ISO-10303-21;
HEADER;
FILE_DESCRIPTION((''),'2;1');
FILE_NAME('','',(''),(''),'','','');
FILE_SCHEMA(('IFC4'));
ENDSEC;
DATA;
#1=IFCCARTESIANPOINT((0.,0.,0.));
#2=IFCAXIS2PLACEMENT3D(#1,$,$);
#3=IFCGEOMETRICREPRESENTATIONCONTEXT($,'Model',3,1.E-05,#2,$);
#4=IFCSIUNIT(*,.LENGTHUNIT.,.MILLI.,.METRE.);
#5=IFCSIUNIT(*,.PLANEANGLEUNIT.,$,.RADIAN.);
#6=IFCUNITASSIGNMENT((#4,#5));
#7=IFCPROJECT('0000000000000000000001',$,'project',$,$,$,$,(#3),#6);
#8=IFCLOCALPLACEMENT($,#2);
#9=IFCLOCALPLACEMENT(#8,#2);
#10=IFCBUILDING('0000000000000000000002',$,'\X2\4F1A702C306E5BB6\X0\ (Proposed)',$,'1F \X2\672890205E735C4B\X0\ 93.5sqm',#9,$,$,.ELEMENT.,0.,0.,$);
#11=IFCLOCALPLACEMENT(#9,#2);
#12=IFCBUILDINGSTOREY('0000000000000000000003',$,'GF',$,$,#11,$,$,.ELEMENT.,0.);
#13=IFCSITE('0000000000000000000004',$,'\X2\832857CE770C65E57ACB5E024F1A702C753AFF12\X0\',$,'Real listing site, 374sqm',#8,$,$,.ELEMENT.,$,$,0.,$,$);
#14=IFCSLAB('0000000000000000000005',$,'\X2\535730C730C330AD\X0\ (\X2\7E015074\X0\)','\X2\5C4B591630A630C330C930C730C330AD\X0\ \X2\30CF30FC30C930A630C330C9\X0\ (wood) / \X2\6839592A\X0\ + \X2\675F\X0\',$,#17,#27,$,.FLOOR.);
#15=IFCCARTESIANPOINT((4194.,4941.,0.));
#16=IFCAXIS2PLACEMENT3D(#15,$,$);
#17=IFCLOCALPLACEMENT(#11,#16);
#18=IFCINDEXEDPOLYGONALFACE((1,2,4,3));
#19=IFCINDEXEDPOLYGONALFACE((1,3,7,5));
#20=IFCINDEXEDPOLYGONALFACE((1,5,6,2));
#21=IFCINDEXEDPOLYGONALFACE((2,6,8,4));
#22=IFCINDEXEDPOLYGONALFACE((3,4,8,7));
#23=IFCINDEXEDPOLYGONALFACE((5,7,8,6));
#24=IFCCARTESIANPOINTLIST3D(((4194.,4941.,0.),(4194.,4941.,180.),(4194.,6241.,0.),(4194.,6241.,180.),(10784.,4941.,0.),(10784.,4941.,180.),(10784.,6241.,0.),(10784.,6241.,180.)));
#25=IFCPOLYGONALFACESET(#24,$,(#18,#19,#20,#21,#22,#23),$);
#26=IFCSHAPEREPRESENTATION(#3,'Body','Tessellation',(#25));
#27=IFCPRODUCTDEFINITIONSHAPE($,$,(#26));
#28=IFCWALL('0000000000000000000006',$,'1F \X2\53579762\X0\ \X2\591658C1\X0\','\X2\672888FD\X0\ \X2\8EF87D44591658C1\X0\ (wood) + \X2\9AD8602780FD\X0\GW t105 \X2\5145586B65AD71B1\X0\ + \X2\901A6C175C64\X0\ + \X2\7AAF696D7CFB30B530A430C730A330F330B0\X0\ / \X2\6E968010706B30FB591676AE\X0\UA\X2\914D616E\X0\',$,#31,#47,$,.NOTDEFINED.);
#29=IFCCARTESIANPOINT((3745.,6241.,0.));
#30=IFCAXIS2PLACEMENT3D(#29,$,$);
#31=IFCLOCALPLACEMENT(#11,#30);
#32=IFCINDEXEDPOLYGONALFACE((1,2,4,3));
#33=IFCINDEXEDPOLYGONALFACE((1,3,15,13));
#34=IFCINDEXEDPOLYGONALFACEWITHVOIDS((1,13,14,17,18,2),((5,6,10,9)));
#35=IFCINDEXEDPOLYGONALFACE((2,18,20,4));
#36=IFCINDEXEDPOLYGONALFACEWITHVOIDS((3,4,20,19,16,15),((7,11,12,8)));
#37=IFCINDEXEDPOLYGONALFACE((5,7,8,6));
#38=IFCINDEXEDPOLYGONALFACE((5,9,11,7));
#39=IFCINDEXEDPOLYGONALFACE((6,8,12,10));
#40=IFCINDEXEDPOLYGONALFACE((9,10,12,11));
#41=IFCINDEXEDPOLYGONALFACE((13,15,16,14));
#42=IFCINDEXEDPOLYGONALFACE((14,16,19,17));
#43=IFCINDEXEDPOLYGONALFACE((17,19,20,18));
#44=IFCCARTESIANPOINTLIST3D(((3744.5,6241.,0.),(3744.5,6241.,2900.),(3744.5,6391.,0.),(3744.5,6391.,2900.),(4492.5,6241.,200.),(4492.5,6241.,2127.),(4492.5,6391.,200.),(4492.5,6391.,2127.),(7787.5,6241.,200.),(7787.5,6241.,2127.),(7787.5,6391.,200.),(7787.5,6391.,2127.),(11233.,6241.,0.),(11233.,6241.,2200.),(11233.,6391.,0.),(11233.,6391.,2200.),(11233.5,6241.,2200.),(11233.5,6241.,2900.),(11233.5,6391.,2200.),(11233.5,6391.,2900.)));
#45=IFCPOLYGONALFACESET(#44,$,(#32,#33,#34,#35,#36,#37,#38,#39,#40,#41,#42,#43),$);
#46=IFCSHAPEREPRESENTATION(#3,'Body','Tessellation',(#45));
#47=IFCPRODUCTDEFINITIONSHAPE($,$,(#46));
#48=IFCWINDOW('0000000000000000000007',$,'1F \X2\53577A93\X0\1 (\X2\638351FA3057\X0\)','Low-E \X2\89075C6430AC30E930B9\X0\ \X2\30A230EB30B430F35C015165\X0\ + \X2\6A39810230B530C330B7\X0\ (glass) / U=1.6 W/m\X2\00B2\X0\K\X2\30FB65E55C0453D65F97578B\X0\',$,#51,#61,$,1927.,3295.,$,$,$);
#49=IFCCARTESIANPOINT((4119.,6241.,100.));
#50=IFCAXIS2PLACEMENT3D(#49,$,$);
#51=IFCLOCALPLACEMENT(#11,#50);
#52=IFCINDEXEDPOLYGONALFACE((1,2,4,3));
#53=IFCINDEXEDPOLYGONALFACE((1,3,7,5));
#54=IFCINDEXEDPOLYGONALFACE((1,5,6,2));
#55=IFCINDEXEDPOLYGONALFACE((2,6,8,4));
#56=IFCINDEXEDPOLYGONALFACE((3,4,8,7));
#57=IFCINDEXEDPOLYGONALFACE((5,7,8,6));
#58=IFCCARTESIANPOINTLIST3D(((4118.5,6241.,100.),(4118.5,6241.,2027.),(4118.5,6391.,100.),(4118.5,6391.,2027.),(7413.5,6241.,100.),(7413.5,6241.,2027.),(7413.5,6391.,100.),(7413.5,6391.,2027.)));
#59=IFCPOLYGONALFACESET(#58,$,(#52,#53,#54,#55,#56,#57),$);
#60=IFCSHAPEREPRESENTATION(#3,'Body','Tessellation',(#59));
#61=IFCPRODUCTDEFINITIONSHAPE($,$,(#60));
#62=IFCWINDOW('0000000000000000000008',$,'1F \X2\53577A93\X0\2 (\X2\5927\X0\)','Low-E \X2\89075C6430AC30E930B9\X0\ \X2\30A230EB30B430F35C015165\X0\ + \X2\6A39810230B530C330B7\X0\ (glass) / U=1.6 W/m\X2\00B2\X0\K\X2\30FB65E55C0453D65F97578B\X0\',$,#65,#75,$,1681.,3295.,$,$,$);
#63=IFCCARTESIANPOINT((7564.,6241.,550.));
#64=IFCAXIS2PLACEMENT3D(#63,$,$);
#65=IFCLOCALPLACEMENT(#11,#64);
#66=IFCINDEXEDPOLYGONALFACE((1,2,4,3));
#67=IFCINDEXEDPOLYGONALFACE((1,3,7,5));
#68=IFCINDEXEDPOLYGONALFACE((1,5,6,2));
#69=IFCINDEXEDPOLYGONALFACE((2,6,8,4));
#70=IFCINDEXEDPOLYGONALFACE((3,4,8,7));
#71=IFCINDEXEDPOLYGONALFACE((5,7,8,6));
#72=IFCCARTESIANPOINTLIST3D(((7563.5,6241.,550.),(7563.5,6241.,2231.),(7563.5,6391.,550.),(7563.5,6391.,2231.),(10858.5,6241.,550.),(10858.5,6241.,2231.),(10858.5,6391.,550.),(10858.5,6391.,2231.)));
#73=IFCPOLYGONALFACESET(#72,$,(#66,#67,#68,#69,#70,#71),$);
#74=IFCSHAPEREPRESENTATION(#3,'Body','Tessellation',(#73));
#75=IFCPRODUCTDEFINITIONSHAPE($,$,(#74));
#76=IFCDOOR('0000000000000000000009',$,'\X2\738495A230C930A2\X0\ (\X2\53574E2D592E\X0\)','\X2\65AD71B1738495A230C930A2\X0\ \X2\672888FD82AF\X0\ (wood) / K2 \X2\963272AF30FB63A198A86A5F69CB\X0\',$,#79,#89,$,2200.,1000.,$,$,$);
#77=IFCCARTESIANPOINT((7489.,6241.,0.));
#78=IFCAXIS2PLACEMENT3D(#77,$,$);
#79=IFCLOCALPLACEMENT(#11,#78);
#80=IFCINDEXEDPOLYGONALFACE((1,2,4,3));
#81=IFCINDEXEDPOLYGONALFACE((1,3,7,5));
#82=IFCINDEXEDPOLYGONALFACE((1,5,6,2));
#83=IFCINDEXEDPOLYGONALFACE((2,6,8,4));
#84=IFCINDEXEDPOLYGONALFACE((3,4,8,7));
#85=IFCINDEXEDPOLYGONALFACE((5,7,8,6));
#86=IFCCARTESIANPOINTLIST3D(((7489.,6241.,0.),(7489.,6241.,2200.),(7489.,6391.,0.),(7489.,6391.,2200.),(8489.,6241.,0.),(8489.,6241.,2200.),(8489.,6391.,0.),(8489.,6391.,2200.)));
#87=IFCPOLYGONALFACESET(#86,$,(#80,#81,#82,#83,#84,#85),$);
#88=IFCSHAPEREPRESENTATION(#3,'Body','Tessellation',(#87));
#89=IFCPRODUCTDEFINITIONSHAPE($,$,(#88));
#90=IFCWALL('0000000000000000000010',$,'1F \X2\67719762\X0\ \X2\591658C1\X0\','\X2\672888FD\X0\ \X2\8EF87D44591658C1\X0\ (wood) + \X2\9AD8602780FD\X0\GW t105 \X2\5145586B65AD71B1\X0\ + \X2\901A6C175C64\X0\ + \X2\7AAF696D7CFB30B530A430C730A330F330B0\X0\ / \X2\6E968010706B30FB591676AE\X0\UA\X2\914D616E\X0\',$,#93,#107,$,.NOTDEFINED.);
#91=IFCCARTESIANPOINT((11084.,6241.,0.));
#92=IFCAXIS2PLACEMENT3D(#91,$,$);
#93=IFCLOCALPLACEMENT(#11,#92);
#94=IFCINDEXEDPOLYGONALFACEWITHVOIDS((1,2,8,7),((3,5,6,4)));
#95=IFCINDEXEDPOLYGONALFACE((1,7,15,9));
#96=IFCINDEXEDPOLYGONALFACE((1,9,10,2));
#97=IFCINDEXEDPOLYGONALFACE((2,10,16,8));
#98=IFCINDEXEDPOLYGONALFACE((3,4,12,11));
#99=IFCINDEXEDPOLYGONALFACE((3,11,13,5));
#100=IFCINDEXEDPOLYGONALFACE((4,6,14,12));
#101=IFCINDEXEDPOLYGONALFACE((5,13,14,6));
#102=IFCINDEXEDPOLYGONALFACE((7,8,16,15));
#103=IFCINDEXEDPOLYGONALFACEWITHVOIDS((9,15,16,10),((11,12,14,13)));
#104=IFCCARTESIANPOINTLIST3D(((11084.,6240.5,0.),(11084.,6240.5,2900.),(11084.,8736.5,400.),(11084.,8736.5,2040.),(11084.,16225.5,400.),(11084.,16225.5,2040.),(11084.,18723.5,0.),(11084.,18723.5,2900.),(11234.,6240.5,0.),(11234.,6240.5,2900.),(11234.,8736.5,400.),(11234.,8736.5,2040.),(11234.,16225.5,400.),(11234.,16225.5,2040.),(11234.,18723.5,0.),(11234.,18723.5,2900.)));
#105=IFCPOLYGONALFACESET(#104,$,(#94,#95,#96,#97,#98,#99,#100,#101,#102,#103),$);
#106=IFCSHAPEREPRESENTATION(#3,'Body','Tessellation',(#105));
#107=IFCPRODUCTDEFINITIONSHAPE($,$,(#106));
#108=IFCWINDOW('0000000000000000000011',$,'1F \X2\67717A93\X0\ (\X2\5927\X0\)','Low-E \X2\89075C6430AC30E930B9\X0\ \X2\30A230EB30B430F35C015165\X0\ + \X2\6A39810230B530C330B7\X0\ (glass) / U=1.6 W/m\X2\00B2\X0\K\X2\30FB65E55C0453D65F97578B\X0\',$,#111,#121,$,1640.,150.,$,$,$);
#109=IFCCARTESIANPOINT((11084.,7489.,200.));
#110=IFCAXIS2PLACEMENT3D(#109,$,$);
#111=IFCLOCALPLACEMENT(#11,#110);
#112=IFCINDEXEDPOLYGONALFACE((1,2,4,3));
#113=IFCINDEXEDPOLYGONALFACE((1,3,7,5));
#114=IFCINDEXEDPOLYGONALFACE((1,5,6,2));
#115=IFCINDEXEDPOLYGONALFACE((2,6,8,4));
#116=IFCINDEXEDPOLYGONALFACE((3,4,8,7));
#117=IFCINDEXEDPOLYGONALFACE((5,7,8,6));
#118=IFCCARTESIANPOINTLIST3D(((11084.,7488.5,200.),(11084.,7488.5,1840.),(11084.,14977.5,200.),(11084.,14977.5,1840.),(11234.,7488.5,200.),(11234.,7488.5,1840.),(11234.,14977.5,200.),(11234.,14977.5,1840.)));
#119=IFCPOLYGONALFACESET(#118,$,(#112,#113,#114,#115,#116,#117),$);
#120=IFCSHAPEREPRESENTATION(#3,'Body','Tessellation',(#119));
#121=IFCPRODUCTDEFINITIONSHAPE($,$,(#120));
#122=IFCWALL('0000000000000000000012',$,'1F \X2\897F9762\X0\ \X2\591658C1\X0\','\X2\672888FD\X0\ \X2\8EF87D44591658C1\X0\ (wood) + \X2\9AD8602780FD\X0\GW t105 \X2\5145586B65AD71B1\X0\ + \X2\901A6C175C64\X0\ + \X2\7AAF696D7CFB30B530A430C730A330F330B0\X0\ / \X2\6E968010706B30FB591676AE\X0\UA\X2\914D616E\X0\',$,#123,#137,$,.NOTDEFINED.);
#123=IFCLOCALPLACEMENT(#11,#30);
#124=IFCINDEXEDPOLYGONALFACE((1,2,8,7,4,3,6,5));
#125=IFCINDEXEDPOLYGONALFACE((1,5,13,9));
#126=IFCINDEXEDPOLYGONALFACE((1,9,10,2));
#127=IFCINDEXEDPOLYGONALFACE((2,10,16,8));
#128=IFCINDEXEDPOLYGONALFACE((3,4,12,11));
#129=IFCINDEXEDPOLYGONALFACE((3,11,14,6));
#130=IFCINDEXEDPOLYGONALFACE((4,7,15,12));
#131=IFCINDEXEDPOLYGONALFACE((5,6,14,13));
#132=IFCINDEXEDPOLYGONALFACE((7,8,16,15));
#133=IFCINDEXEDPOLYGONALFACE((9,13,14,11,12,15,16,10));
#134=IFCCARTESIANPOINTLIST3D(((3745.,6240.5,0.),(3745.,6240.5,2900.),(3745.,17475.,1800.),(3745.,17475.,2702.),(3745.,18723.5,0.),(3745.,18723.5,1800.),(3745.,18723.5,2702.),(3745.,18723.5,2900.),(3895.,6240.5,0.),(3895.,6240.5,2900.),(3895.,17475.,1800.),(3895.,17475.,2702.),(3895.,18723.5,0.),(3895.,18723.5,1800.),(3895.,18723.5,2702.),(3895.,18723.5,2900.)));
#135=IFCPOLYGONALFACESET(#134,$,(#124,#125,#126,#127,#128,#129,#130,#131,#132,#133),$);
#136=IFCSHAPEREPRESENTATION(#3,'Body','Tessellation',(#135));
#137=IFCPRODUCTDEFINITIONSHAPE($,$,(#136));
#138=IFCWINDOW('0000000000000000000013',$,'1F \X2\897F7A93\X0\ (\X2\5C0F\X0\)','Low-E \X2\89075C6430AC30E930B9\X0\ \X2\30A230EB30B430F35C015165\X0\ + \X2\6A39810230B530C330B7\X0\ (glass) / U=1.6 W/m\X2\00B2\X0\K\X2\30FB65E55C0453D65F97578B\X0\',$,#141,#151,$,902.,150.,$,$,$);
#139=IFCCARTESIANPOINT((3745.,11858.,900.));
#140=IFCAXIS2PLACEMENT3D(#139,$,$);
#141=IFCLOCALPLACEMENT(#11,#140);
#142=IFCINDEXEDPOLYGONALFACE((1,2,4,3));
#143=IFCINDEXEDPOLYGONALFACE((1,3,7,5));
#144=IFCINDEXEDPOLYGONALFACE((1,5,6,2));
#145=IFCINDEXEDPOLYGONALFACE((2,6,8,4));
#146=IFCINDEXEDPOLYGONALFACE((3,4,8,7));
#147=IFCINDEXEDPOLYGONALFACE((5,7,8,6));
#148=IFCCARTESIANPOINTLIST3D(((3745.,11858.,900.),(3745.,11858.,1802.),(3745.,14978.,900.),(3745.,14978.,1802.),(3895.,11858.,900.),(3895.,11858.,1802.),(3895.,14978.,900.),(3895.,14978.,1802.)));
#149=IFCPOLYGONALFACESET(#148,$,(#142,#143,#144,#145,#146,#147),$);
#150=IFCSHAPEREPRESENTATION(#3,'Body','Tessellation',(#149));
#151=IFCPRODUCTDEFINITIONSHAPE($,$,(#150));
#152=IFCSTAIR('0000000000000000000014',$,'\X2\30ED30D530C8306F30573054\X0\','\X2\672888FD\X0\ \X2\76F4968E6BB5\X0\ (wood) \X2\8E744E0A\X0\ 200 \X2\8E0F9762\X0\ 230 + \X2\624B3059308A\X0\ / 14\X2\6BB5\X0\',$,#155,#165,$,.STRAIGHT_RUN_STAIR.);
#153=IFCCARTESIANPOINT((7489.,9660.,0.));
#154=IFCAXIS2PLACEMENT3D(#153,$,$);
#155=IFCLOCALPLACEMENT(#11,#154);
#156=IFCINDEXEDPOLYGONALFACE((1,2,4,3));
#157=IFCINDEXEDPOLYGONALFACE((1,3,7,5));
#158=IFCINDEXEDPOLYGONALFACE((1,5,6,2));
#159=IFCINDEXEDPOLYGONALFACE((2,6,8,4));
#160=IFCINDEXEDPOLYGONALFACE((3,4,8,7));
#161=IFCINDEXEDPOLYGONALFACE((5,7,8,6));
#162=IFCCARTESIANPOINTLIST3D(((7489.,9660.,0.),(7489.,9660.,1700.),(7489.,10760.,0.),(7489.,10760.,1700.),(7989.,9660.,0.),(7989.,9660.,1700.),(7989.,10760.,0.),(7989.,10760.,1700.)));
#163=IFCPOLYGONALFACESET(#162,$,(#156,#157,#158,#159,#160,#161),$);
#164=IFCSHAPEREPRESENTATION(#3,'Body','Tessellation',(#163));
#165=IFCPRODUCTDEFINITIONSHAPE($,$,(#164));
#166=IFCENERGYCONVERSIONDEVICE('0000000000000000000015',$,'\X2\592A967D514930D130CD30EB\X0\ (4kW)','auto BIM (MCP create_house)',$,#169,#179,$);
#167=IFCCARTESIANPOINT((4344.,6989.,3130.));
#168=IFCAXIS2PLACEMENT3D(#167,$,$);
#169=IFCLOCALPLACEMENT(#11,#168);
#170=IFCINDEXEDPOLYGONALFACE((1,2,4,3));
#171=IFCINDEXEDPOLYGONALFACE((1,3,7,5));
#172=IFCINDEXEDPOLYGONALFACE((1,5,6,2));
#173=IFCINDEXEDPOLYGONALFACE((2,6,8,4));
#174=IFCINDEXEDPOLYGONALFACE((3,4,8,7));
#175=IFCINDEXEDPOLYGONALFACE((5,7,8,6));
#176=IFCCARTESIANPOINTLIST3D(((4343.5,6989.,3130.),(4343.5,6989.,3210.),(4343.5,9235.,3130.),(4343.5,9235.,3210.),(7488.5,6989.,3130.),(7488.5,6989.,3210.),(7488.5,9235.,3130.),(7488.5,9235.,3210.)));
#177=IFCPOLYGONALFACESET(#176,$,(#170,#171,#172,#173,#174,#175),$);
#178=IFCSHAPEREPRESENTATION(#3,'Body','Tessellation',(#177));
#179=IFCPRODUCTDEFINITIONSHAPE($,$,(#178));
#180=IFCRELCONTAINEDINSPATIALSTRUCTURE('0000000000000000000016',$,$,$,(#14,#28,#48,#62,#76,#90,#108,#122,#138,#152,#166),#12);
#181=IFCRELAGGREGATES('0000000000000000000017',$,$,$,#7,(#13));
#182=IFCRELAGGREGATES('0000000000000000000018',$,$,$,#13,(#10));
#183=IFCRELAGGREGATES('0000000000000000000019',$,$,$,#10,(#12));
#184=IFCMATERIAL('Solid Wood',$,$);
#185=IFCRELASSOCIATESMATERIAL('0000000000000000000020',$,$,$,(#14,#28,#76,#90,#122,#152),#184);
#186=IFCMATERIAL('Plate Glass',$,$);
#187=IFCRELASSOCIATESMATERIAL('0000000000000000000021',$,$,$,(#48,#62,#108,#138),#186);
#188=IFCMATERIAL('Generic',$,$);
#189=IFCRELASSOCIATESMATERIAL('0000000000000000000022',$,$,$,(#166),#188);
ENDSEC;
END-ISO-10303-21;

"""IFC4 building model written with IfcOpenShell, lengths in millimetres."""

from ifc_helpers import new_model, si_unit, frame, frame_2d, origin, place, context, project, spatial, rectangle, extrude, material, element, fill, save


model = new_model("IFC4")

# Units and contexts
model_context = context("Model", 3, precision=1e-05, world=origin())
ifc_project = project(units=[si_unit("LENGTHUNIT", "METRE", prefix="MILLI"), si_unit("PLANEANGLEUNIT", "RADIAN")], contexts=[model_context])

# Site, building, storey
site_placement = place(None, origin())
site = spatial("IfcSite", under=ifc_project, at=site_placement, Name="茨城県日立市会瀬町２", ObjectType="Real listing site, 374sqm", CompositionType="ELEMENT", RefElevation=0.0)
building_placement = place(site_placement, origin())
building = spatial("IfcBuilding", under=site, at=building_placement, Name="会瀬の家 (Proposed)", ObjectType="1F 木造平屋 93.5sqm", CompositionType="ELEMENT", ElevationOfRefHeight=0.0, ElevationOfTerrain=0.0)
storey_placement = place(building_placement, origin())
storey = spatial("IfcBuildingStorey", under=building, at=storey_placement, Name="GF", CompositionType="ELEMENT", Elevation=0.0)

# Slab
ifc_material_1 = material(Name="Solid Wood")
slab_1_placement = place(storey_placement, frame((4194.0, 4941.0, 0.0)))
element("IfcSlab", 1, at=slab_1_placement, inside=storey, material=ifc_material_1, Name="南デッキ (縁側)", Description="屋外ウッドデッキ ハードウッド (wood) / 根太 + 束", PredefinedType="FLOOR", context=model_context, shape_type="SweptSolid", body=[
    extrude(rectangle(XDim=6590.0, YDim=1300.0, at=frame_2d((3295.0, 650.0))), frame((4194.0, 4941.0, 0.0)), (0.0, 0.0, 1.0), 180.0),
])

# Wall, openings, windows, door
wall_1_placement = place(storey_placement, frame((3745.0, 6241.0, 0.0)))
wall_1 = element("IfcWall", 2, at=wall_1_placement, inside=storey, material=ifc_material_1, Name="1F 南面 外壁", Description="木製 軸組外壁 (wood) + 高性能GW t105 充填断熱 + 通気層 + 窯業系サイディング / 準耐火・外皮UA配慮", PredefinedType="NOTDEFINED", context=model_context, shape_type="SweptSolid", body=[
    extrude(rectangle(XDim=7489.0, YDim=150.0, at=frame_2d((3744.0, 75.0))), frame((3745.0, 6241.0, 0.0)), (0.0, 0.0, 1.0), 2900.0),
])
opening_1_placement = place(storey_placement, frame((4119.0, 6241.0, 100.0)))
opening_1 = element("IfcOpeningElement", 3, at=opening_1_placement, cuts=wall_1, PredefinedType="NOTDEFINED", context=model_context, shape_type="SweptSolid", body=[
    extrude(rectangle(XDim=3295.0, YDim=150.0, at=frame_2d((1647.0, 75.0))), frame((4119.0, 6241.0, 100.0)), (0.0, 0.0, 1.0), 1927.0),
])
opening_2_placement = place(storey_placement, frame((7564.0, 6241.0, 550.0)))
opening_2 = element("IfcOpeningElement", 4, at=opening_2_placement, cuts=wall_1, PredefinedType="NOTDEFINED", context=model_context, shape_type="SweptSolid", body=[
    extrude(rectangle(XDim=3295.0, YDim=150.0, at=frame_2d((1647.0, 75.0))), frame((7564.0, 6241.0, 550.0)), (0.0, 0.0, 1.0), 1681.0),
])
opening_3_placement = place(storey_placement, frame((7489.0, 6241.0, 0.0)))
opening_3 = element("IfcOpeningElement", 5, at=opening_3_placement, cuts=wall_1, PredefinedType="NOTDEFINED", context=model_context, shape_type="SweptSolid", body=[
    extrude(rectangle(XDim=1000.0, YDim=150.0, at=frame_2d((500.0, 75.0))), frame((7489.0, 6241.0, 0.0)), (0.0, 0.0, 1.0), 2200.0),
])
ifc_material_2 = material(Name="Plate Glass")
window_1_placement = place(storey_placement, frame((4119.0, 6241.0, 100.0)))
window_1 = element("IfcWindow", 6, at=window_1_placement, inside=storey, material=ifc_material_2, Name="1F 南窓1 (掃出し)", Description="Low-E 複層ガラス アルゴン封入 + 樹脂サッシ (glass) / U=1.6 W/m²K・日射取得型", OverallHeight=1927.0, OverallWidth=3295.0, context=model_context, shape_type="SweptSolid", body=[
    extrude(rectangle(XDim=3295.0, YDim=150.0, at=frame_2d((1647.0, 75.0))), frame((4119.0, 6241.0, 100.0)), (0.0, 0.0, 1.0), 1927.0),
])
fill(opening_1, window_1)
window_2_placement = place(storey_placement, frame((7564.0, 6241.0, 550.0)))
window_2 = element("IfcWindow", 7, at=window_2_placement, inside=storey, material=ifc_material_2, Name="1F 南窓2 (大)", Description="Low-E 複層ガラス アルゴン封入 + 樹脂サッシ (glass) / U=1.6 W/m²K・日射取得型", OverallHeight=1681.0, OverallWidth=3295.0, context=model_context, shape_type="SweptSolid", body=[
    extrude(rectangle(XDim=3295.0, YDim=150.0, at=frame_2d((1647.0, 75.0))), frame((7564.0, 6241.0, 550.0)), (0.0, 0.0, 1.0), 1681.0),
])
fill(opening_2, window_2)
door_placement = place(storey_placement, frame((7489.0, 6241.0, 0.0)))
door = element("IfcDoor", 8, at=door_placement, inside=storey, material=ifc_material_1, Name="玄関ドア (南中央)", Description="断熱玄関ドア 木製芯 (wood) / K2 防犯・採風機構", OverallHeight=2200.0, OverallWidth=1000.0, context=model_context, shape_type="SweptSolid", body=[
    extrude(rectangle(XDim=1000.0, YDim=150.0, at=frame_2d((500.0, 75.0))), frame((7489.0, 6241.0, 0.0)), (0.0, 0.0, 1.0), 2200.0),
])
fill(opening_3, door)

# Walls, openings, windows
wall_2_placement = place(storey_placement, frame((11084.0, 6241.0, 0.0)))
wall_2 = element("IfcWall", 9, at=wall_2_placement, inside=storey, material=ifc_material_1, Name="1F 東面 外壁", Description="木製 軸組外壁 (wood) + 高性能GW t105 充填断熱 + 通気層 + 窯業系サイディング / 準耐火・外皮UA配慮", PredefinedType="NOTDEFINED", context=model_context, shape_type="SweptSolid", body=[
    extrude(rectangle(XDim=150.0, YDim=12483.0, at=frame_2d((75.0, 6241.0))), frame((11084.0, 6241.0, 0.0)), (0.0, 0.0, 1.0), 2900.0),
])
opening_4_placement = place(storey_placement, frame((11084.0, 7489.0, 200.0)))
opening_4 = element("IfcOpeningElement", 10, at=opening_4_placement, cuts=wall_2, PredefinedType="NOTDEFINED", context=model_context, shape_type="SweptSolid", body=[
    extrude(rectangle(XDim=150.0, YDim=7489.0, at=frame_2d((75.0, 3744.0))), frame((11084.0, 7489.0, 200.0)), (0.0, 0.0, 1.0), 1640.0),
])
window_3_placement = place(storey_placement, frame((11084.0, 7489.0, 200.0)))
window_3 = element("IfcWindow", 11, at=window_3_placement, inside=storey, material=ifc_material_2, Name="1F 東窓 (大)", Description="Low-E 複層ガラス アルゴン封入 + 樹脂サッシ (glass) / U=1.6 W/m²K・日射取得型", OverallHeight=1640.0, OverallWidth=150.0, context=model_context, shape_type="SweptSolid", body=[
    extrude(rectangle(XDim=150.0, YDim=7489.0, at=frame_2d((75.0, 3744.0))), frame((11084.0, 7489.0, 200.0)), (0.0, 0.0, 1.0), 1640.0),
])
fill(opening_4, window_3)
wall_3_placement = place(storey_placement, frame((3745.0, 6241.0, 0.0)))
wall_3 = element("IfcWall", 12, at=wall_3_placement, inside=storey, material=ifc_material_1, Name="1F 西面 外壁", Description="木製 軸組外壁 (wood) + 高性能GW t105 充填断熱 + 通気層 + 窯業系サイディング / 準耐火・外皮UA配慮", PredefinedType="NOTDEFINED", context=model_context, shape_type="SweptSolid", body=[
    extrude(rectangle(XDim=150.0, YDim=12483.0, at=frame_2d((75.0, 6241.0))), frame((3745.0, 6241.0, 0.0)), (0.0, 0.0, 1.0), 2900.0),
])
opening_5_placement = place(storey_placement, frame((3745.0, 11858.0, 900.0)))
opening_5 = element("IfcOpeningElement", 13, at=opening_5_placement, cuts=wall_3, PredefinedType="NOTDEFINED", context=model_context, shape_type="SweptSolid", body=[
    extrude(rectangle(XDim=150.0, YDim=3120.0, at=frame_2d((75.0, 1560.0))), frame((3745.0, 11858.0, 900.0)), (0.0, 0.0, 1.0), 902.0),
])
window_4_placement = place(storey_placement, frame((3745.0, 11858.0, 900.0)))
window_4 = element("IfcWindow", 14, at=window_4_placement, inside=storey, material=ifc_material_2, Name="1F 西窓 (小)", Description="Low-E 複層ガラス アルゴン封入 + 樹脂サッシ (glass) / U=1.6 W/m²K・日射取得型", OverallHeight=902.0, OverallWidth=150.0, context=model_context, shape_type="SweptSolid", body=[
    extrude(rectangle(XDim=150.0, YDim=3120.0, at=frame_2d((75.0, 1560.0))), frame((3745.0, 11858.0, 900.0)), (0.0, 0.0, 1.0), 902.0),
])
fill(opening_5, window_4)

# Stair
stair_placement = place(storey_placement, frame((7489.0, 9660.0, 0.0)))
element("IfcStair", 15, at=stair_placement, inside=storey, material=ifc_material_1, Name="ロフトはしご", Description="木製 直階段 (wood) 蹴上 200 踏面 230 + 手すり / 14段", PredefinedType="STRAIGHT_RUN_STAIR", context=model_context, shape_type="SweptSolid", body=[
    extrude(rectangle(XDim=500.0, YDim=1100.0, at=frame_2d((250.0, 550.0))), frame((7489.0, 9660.0, 0.0)), (0.0, 0.0, 1.0), 1700.0),
])

# Shared definitions
ifc_material_3 = material(Name="Generic")

# Energy conversion device
energy_conversion_device_placement = place(storey_placement, frame((4344.0, 6989.0, 3130.0)))
element("IfcEnergyConversionDevice", 16, at=energy_conversion_device_placement, inside=storey, material=ifc_material_3, Name="太陽光パネル (4kW)", Description="auto BIM (MCP create_house)", context=model_context, shape_type="SweptSolid", body=[
    extrude(rectangle(XDim=3145.0, YDim=2246.0, at=frame_2d((1572.0, 1123.0))), frame((4344.0, 6989.0, 3130.0)), (0.0, 0.0, 1.0), 80.0),
])

save(model, "model.ifc")
